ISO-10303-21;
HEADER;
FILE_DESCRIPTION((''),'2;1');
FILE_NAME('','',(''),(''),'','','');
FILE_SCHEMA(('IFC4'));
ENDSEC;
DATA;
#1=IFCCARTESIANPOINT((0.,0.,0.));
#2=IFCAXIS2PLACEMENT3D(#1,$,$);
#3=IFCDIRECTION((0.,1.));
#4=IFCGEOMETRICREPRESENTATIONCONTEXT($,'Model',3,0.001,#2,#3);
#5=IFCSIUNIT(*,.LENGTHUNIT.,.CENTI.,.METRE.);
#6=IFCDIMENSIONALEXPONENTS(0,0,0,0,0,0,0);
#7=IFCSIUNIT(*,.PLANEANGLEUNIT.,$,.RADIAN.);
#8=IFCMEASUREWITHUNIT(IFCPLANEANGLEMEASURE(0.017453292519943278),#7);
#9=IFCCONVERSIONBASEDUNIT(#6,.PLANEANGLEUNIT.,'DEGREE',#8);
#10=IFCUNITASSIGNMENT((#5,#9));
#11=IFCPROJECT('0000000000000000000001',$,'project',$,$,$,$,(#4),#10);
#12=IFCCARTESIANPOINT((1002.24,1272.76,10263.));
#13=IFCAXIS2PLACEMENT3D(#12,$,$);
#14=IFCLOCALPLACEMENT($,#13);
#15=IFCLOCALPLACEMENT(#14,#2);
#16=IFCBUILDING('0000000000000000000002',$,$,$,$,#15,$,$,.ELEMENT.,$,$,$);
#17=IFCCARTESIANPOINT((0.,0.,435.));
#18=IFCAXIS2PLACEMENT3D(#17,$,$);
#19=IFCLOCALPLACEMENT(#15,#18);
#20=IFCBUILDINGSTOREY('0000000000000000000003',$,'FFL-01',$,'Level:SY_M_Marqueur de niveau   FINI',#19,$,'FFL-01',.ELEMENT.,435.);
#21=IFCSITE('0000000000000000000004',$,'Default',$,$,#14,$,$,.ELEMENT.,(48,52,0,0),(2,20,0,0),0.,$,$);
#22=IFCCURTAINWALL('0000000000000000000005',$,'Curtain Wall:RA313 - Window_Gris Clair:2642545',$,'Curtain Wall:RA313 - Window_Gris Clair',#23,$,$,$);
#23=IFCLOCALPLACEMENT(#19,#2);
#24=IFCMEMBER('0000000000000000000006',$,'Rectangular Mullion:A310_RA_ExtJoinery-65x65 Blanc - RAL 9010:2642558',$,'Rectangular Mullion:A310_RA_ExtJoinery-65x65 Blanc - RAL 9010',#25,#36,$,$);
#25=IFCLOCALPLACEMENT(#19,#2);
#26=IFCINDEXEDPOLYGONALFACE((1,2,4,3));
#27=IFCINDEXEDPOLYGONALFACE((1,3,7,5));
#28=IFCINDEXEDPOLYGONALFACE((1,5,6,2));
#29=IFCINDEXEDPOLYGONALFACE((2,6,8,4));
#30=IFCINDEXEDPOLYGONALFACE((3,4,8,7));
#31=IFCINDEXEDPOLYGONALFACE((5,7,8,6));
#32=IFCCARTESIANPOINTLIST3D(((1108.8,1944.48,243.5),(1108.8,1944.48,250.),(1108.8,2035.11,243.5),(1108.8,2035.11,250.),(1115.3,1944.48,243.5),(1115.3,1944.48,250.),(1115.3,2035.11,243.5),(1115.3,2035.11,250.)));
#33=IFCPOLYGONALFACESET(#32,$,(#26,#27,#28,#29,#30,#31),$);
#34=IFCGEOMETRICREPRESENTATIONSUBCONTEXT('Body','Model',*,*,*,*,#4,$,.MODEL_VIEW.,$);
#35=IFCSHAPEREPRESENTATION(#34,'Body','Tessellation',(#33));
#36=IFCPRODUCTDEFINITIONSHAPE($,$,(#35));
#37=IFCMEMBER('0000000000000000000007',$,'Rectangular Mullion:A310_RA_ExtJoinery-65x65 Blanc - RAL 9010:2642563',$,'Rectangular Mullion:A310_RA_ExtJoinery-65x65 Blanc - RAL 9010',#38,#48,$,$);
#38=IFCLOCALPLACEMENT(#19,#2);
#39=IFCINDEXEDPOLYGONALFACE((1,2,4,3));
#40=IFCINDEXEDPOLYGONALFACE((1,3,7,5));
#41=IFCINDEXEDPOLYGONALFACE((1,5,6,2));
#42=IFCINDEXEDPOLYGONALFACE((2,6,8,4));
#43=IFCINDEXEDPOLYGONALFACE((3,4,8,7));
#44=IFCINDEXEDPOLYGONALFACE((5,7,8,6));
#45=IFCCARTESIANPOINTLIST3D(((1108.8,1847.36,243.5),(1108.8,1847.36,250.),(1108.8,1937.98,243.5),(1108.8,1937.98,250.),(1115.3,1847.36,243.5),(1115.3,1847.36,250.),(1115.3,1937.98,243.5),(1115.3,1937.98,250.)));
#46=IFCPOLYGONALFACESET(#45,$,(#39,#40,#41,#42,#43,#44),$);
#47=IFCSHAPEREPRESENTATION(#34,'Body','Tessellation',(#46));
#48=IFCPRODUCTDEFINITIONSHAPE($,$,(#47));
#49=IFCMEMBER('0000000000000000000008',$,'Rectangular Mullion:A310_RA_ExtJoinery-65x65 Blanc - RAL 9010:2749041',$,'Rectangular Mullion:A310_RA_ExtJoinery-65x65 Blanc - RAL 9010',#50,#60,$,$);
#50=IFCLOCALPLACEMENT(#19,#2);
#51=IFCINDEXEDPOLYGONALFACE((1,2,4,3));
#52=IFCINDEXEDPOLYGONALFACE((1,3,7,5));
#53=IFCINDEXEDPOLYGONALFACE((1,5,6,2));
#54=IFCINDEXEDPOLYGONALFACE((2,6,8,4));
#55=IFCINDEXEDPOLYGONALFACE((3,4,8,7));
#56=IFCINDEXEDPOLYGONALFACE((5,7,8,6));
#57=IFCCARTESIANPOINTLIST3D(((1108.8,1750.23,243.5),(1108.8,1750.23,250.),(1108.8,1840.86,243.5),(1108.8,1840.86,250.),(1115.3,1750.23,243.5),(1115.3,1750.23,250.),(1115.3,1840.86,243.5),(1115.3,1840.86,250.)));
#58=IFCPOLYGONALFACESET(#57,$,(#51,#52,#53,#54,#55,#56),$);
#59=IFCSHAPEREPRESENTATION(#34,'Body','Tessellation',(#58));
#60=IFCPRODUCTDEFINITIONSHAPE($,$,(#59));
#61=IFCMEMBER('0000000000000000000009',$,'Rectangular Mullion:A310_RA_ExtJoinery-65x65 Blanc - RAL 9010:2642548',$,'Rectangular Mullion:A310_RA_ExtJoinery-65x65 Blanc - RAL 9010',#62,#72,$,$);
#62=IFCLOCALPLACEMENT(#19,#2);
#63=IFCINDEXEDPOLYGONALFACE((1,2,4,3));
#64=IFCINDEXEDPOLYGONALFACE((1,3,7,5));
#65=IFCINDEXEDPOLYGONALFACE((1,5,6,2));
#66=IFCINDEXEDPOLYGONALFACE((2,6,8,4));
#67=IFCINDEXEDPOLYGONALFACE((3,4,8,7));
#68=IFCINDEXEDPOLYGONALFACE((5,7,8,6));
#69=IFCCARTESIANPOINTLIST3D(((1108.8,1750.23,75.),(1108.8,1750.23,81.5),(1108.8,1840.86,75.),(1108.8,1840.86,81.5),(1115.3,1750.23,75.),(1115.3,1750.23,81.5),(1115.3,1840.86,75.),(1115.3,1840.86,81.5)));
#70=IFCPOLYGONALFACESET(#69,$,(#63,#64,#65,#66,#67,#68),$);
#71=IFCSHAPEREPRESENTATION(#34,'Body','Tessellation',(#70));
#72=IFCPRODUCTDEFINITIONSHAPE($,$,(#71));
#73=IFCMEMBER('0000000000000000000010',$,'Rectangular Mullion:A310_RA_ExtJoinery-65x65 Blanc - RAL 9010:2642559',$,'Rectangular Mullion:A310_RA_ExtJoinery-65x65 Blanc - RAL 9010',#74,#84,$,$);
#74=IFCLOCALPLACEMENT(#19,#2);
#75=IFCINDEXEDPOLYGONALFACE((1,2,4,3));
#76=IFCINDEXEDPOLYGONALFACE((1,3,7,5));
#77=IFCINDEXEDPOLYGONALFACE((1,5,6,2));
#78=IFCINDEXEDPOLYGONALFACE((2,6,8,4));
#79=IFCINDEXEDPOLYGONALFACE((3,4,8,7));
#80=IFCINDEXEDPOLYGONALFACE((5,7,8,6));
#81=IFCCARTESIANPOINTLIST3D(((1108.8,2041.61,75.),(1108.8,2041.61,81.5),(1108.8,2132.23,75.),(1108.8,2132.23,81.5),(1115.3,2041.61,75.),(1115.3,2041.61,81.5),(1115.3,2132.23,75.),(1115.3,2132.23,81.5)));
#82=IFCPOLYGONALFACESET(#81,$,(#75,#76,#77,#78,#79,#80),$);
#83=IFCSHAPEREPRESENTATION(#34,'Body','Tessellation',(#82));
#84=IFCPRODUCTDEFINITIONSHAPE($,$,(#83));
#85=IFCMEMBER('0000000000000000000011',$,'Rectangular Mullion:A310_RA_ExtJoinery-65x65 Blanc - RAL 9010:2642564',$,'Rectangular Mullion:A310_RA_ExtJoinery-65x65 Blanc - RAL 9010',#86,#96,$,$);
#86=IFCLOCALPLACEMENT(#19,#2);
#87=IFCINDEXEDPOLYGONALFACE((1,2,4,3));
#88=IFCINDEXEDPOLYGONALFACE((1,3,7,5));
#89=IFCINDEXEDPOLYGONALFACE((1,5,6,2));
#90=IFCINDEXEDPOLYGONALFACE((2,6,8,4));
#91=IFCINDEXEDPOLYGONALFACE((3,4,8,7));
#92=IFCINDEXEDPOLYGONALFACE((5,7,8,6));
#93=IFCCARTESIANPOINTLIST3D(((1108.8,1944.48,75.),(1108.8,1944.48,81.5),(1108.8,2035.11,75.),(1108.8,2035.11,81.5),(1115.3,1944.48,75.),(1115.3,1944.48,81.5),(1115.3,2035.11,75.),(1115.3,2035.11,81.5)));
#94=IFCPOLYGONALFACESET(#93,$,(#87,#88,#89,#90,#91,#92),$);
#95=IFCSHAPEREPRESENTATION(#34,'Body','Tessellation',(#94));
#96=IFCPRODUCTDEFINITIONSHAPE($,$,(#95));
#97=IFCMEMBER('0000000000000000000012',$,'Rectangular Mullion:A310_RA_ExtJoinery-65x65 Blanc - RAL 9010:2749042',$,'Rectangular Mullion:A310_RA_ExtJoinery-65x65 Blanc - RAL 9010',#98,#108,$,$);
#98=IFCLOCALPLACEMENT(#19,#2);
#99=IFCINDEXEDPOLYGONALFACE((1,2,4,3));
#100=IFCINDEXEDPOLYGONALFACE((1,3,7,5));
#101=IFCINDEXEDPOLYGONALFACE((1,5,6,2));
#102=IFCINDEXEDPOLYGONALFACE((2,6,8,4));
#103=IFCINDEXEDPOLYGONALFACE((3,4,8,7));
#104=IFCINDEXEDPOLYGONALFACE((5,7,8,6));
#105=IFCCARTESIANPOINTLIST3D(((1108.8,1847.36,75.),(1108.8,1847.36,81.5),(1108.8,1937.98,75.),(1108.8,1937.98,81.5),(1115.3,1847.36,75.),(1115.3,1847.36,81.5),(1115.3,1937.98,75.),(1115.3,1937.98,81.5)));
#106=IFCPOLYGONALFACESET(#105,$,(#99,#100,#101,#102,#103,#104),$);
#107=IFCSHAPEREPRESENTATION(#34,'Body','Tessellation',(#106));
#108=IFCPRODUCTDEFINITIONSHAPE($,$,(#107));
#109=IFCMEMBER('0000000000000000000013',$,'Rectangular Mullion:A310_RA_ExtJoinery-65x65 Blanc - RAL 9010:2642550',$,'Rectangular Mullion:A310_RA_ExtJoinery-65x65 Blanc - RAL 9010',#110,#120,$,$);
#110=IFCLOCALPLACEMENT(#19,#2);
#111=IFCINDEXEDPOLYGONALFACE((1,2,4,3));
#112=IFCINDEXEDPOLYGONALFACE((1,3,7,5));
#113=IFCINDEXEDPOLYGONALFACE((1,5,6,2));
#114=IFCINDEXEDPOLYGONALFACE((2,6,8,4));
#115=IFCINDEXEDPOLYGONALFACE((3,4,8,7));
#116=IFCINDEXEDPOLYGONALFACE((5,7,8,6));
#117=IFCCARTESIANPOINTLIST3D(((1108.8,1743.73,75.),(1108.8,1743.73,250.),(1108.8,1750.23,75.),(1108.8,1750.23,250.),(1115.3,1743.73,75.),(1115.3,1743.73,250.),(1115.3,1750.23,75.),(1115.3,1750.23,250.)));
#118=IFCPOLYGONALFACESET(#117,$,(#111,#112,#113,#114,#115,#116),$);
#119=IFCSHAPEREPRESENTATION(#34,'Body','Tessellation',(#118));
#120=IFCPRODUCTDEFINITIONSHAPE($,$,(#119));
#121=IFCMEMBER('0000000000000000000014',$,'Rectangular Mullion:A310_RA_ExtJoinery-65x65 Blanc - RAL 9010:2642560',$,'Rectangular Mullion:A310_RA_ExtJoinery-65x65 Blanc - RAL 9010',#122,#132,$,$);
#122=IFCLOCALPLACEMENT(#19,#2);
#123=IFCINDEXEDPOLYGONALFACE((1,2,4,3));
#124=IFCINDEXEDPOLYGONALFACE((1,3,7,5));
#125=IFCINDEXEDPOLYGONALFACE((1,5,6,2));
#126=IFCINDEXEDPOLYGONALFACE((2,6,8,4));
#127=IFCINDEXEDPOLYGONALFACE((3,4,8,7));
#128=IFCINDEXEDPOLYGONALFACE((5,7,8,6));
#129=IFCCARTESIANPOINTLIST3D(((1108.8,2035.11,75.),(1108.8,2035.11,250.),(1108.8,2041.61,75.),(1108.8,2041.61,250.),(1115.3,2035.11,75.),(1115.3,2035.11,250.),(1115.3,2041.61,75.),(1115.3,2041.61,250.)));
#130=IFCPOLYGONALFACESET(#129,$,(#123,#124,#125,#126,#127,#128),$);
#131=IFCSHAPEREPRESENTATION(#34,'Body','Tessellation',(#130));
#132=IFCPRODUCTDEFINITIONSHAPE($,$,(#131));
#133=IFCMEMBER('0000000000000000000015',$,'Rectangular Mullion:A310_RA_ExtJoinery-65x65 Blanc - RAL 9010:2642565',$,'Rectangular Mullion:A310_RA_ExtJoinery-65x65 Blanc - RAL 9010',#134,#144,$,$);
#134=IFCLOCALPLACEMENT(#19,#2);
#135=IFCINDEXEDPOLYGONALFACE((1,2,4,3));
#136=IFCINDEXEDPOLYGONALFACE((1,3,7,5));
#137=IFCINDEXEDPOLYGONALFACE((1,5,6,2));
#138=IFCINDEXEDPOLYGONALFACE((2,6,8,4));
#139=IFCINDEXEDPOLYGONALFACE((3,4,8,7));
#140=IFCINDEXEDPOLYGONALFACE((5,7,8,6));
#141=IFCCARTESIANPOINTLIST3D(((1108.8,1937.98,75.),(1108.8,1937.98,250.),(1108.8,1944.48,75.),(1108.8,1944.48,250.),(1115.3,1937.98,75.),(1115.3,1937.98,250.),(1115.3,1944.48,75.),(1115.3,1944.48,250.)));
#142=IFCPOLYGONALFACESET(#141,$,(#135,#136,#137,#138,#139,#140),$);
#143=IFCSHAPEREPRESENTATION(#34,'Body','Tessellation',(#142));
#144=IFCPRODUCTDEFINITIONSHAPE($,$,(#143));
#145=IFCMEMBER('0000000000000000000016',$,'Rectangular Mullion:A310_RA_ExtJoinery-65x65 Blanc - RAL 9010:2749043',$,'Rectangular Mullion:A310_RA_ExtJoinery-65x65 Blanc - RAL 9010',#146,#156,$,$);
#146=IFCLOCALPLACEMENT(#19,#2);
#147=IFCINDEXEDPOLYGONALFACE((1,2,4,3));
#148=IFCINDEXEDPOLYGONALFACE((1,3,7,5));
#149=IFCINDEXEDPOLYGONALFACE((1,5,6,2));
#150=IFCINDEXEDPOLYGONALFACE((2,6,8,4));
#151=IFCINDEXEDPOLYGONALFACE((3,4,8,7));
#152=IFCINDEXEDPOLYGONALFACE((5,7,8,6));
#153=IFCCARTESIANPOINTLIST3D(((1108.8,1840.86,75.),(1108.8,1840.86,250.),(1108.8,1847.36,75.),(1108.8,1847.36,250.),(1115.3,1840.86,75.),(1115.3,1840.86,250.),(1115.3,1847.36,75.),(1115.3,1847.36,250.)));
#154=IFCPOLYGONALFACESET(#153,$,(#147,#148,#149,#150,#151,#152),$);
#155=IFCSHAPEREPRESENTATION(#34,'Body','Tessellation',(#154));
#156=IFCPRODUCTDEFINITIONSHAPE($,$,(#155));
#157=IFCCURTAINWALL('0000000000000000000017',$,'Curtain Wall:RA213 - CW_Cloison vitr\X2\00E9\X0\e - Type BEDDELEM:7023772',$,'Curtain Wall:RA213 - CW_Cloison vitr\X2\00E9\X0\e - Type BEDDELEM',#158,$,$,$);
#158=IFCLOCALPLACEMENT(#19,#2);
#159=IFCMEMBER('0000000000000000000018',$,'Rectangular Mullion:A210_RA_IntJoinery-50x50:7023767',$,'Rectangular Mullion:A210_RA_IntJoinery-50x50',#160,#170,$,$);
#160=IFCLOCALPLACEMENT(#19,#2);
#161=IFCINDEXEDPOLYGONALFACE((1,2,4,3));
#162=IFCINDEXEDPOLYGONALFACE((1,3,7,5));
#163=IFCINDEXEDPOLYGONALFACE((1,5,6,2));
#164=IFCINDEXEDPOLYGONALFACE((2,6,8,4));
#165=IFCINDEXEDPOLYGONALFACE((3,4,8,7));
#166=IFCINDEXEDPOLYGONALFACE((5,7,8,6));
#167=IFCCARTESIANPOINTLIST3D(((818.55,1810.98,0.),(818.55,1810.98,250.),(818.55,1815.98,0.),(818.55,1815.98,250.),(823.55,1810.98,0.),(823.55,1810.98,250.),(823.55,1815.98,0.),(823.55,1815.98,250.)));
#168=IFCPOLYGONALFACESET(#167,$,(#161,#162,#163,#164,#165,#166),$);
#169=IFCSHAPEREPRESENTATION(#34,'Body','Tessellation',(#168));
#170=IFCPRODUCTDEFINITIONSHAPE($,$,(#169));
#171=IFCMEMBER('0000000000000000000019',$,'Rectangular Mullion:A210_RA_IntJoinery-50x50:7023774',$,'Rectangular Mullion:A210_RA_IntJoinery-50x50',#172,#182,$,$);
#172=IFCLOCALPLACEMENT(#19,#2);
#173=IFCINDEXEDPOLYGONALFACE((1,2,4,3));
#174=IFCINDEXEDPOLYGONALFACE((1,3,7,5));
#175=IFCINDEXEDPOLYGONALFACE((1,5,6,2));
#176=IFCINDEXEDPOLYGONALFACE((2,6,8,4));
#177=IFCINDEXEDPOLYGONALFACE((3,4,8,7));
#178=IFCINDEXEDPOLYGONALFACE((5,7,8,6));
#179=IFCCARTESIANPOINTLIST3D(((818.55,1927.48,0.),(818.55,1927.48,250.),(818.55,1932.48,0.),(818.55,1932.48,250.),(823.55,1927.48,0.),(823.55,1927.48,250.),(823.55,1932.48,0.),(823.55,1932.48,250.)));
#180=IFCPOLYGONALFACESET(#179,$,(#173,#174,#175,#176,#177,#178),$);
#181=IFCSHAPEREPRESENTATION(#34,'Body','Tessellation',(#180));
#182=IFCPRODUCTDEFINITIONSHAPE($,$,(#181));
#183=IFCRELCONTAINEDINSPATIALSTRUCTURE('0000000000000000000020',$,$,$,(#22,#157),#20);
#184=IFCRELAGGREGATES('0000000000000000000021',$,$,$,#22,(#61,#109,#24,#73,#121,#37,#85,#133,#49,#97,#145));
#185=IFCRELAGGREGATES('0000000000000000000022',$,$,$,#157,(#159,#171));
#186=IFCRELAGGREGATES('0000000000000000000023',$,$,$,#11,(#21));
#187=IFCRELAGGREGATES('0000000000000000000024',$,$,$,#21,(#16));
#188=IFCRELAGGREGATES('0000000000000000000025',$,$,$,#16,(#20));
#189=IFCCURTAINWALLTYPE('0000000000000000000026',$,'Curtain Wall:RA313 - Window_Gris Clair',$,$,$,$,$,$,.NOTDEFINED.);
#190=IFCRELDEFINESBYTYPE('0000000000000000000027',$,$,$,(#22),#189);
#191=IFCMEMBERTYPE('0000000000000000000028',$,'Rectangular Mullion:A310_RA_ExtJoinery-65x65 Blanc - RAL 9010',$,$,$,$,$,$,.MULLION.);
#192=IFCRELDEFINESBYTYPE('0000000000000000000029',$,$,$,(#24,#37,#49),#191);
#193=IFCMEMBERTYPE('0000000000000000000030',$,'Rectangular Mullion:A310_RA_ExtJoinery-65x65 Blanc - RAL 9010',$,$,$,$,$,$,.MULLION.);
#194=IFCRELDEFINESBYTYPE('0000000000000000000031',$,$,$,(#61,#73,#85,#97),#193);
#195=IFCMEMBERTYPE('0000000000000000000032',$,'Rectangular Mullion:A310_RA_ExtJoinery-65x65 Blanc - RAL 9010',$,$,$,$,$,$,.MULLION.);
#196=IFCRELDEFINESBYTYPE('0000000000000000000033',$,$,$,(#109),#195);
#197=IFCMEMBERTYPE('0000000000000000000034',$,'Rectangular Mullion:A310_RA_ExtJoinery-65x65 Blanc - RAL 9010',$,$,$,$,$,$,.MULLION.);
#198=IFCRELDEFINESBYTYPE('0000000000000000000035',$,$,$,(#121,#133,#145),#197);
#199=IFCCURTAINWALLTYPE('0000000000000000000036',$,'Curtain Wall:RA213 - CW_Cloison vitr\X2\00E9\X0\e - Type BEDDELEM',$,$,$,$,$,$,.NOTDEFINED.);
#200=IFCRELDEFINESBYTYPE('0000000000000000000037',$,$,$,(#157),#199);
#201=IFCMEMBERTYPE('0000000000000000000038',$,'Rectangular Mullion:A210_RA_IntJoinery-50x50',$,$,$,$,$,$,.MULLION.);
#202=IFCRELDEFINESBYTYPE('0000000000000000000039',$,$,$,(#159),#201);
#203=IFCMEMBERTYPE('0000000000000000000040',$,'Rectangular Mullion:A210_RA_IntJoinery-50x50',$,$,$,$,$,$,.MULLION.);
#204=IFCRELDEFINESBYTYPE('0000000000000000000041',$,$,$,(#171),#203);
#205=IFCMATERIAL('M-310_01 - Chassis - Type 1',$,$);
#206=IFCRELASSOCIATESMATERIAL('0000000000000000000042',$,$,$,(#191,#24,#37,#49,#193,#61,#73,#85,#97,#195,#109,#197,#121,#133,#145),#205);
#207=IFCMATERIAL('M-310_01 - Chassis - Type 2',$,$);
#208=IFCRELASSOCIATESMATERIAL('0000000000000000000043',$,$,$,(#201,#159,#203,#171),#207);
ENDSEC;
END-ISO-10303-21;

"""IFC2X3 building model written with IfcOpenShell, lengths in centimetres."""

from ifc_helpers import new_model, entity, si_unit, converted_unit, direction, frame, origin, origin_2d_with_axis, place, context, subcontext, project, spatial, rectangle, extrude, source, transform, mapped, material, type_object, type_shapes, element, aggregate, save


model = new_model("IFC2X3")

# Units and contexts
model_context = context("Model", 3, precision=0.001, world=origin(), true_north=direction((0.0, 1.0)))
body_context = subcontext(model_context, "Body", "Model", "MODEL_VIEW")
ifc_project = project(units=[si_unit("LENGTHUNIT", "METRE", prefix="CENTI"), converted_unit("PLANEANGLEUNIT", "DEGREE", entity("IfcPlaneAngleMeasure", 0.017453292519943278), si_unit("PLANEANGLEUNIT", "RADIAN"), dimensions=[0, 0, 0, 0, 0, 0, 0])], contexts=[model_context])

# Site, building, storey
site_placement = place(None, frame((1002.24, 1272.76, 10263.0)))
site = spatial("IfcSite", under=ifc_project, at=site_placement, Name="Default", CompositionType="ELEMENT", RefLatitude=(48, 52, 0, 0), RefLongitude=(2, 20, 0, 0), RefElevation=0.0)
building_placement = place(site_placement, origin())
building = spatial("IfcBuilding", under=site, at=building_placement, CompositionType="ELEMENT")
storey_placement = place(building_placement, frame((0.0, 0.0, 435.0)))
storey = spatial("IfcBuildingStorey", under=building, at=storey_placement, Name="FFL-01", ObjectType="Level:SY_M_Marqueur de niveau   FINI", LongName="FFL-01", CompositionType="ELEMENT", Elevation=435.0)

# Curtain walls, members
curtain_wall_type_1 = type_object("IfcCurtainWallType", Name="Curtain Wall:RA313 - Window_Gris Clair", PredefinedType="NOTDEFINED")
curtain_wall_1_placement = place(storey_placement, frame((0.0, 0.0, -435.0)))
curtain_wall_1 = element("IfcCurtainWall", 1, at=curtain_wall_1_placement, inside=storey, type_object=curtain_wall_type_1, Name="Curtain Wall:RA313 - Window_Gris Clair:2642545", ObjectType="Curtain Wall:RA313 - Window_Gris Clair")
ifc_material_1 = material(Name="M-310_01 - Chassis - Type 1")
member_type_1 = type_object("IfcMemberType", Name="Rectangular Mullion:A310_RA_ExtJoinery-65x65 Blanc - RAL 9010", PredefinedType="MULLION", material=ifc_material_1)
shared_shape_1 = source(origin(), body_context, "Body", "SweptSolid", [
    extrude(rectangle(XDim=6.5, YDim=6.5, at=origin_2d_with_axis()), frame((-3.25, -3.25, -90.62), z_axis=(0.0, 0.0, 1.0), x_axis=(-1.0, 0.0, 0.0)), (0.0, 0.0, 1.0), 90.62),
])
type_shapes(member_type_1, [shared_shape_1])
member_1_placement = place(curtain_wall_1_placement, frame((1115.3, 2035.11, 685.0), z_axis=(0.0, 1.0, 0.0), x_axis=(0.0, 0.0, 1.0)))
member_1 = element("IfcMember", 2, at=member_1_placement, type_object=member_type_1, material=ifc_material_1, Name="Rectangular Mullion:A310_RA_ExtJoinery-65x65 Blanc - RAL 9010:2642558", ObjectType="Rectangular Mullion:A310_RA_ExtJoinery-65x65 Blanc - RAL 9010", context=body_context, shape_type="MappedRepresentation", body=[
    mapped(shared_shape_1, transform((0.0, 0.0, 0.0), scale=1.0)),
])
member_2_placement = place(curtain_wall_1_placement, frame((1115.3, 1937.98, 685.0), z_axis=(0.0, 1.0, 0.0), x_axis=(0.0, 0.0, 1.0)))
member_2 = element("IfcMember", 3, at=member_2_placement, type_object=member_type_1, material=ifc_material_1, Name="Rectangular Mullion:A310_RA_ExtJoinery-65x65 Blanc - RAL 9010:2642563", ObjectType="Rectangular Mullion:A310_RA_ExtJoinery-65x65 Blanc - RAL 9010", context=body_context, shape_type="MappedRepresentation", body=[
    mapped(shared_shape_1, transform((0.0, 0.0, 0.0), scale=1.0)),
])
member_3_placement = place(curtain_wall_1_placement, frame((1115.3, 1840.86, 685.0), z_axis=(0.0, 1.0, 0.0), x_axis=(0.0, 0.0, 1.0)))
member_3 = element("IfcMember", 4, at=member_3_placement, type_object=member_type_1, material=ifc_material_1, Name="Rectangular Mullion:A310_RA_ExtJoinery-65x65 Blanc - RAL 9010:2749041", ObjectType="Rectangular Mullion:A310_RA_ExtJoinery-65x65 Blanc - RAL 9010", context=body_context, shape_type="MappedRepresentation", body=[
    mapped(shared_shape_1, transform((0.0, 0.0, 0.0), scale=1.0)),
])
member_type_2 = type_object("IfcMemberType", Name="Rectangular Mullion:A310_RA_ExtJoinery-65x65 Blanc - RAL 9010", PredefinedType="MULLION", material=ifc_material_1)
shared_shape_2 = source(origin(), body_context, "Body", "SweptSolid", [
    extrude(rectangle(XDim=6.5, YDim=6.5, at=origin_2d_with_axis()), frame((-3.25, -3.25, -90.62), z_axis=(0.0, 0.0, 1.0), x_axis=(-1.0, 0.0, 0.0)), (0.0, 0.0, 1.0), 90.62),
])
type_shapes(member_type_2, [shared_shape_2])
member_4_placement = place(curtain_wall_1_placement, frame((1115.3, 1750.23, 510.0), z_axis=(0.0, -1.0, 0.0), x_axis=(0.0, 0.0, -1.0)))
member_4 = element("IfcMember", 5, at=member_4_placement, type_object=member_type_2, material=ifc_material_1, Name="Rectangular Mullion:A310_RA_ExtJoinery-65x65 Blanc - RAL 9010:2642548", ObjectType="Rectangular Mullion:A310_RA_ExtJoinery-65x65 Blanc - RAL 9010", context=body_context, shape_type="MappedRepresentation", body=[
    mapped(shared_shape_2, transform((0.0, 0.0, 0.0), scale=1.0)),
])
member_5_placement = place(curtain_wall_1_placement, frame((1115.3, 2041.61, 510.0), z_axis=(0.0, -1.0, 0.0), x_axis=(0.0, 0.0, -1.0)))
member_5 = element("IfcMember", 6, at=member_5_placement, type_object=member_type_2, material=ifc_material_1, Name="Rectangular Mullion:A310_RA_ExtJoinery-65x65 Blanc - RAL 9010:2642559", ObjectType="Rectangular Mullion:A310_RA_ExtJoinery-65x65 Blanc - RAL 9010", context=body_context, shape_type="MappedRepresentation", body=[
    mapped(shared_shape_2, transform((0.0, 0.0, 0.0), scale=1.0)),
])
member_6_placement = place(curtain_wall_1_placement, frame((1115.3, 1944.48, 510.0), z_axis=(0.0, -1.0, 0.0), x_axis=(0.0, 0.0, -1.0)))
member_6 = element("IfcMember", 7, at=member_6_placement, type_object=member_type_2, material=ifc_material_1, Name="Rectangular Mullion:A310_RA_ExtJoinery-65x65 Blanc - RAL 9010:2642564", ObjectType="Rectangular Mullion:A310_RA_ExtJoinery-65x65 Blanc - RAL 9010", context=body_context, shape_type="MappedRepresentation", body=[
    mapped(shared_shape_2, transform((0.0, 0.0, 0.0), scale=1.0)),
])
member_7_placement = place(curtain_wall_1_placement, frame((1115.3, 1847.36, 510.0), z_axis=(0.0, -1.0, 0.0), x_axis=(0.0, 0.0, -1.0)))
member_7 = element("IfcMember", 8, at=member_7_placement, type_object=member_type_2, material=ifc_material_1, Name="Rectangular Mullion:A310_RA_ExtJoinery-65x65 Blanc - RAL 9010:2749042", ObjectType="Rectangular Mullion:A310_RA_ExtJoinery-65x65 Blanc - RAL 9010", context=body_context, shape_type="MappedRepresentation", body=[
    mapped(shared_shape_2, transform((0.0, 0.0, 0.0), scale=1.0)),
])
member_type_3 = type_object("IfcMemberType", Name="Rectangular Mullion:A310_RA_ExtJoinery-65x65 Blanc - RAL 9010", PredefinedType="MULLION", material=ifc_material_1)
shared_shape_3 = source(origin(), body_context, "Body", "SweptSolid", [
    extrude(rectangle(XDim=6.5, YDim=6.5, at=origin_2d_with_axis()), frame((-3.25, -3.25, -175.0), z_axis=(0.0, 0.0, 1.0), x_axis=(-1.0, 0.0, 0.0)), (0.0, 0.0, 1.0), 175.0),
])
type_shapes(member_type_3, [shared_shape_3])
member_8_placement = place(curtain_wall_1_placement, frame((1115.3, 1743.73, 685.0), z_axis=(0.0, 0.0, 1.0), x_axis=(0.0, -1.0, 0.0)))
member_8 = element("IfcMember", 9, at=member_8_placement, type_object=member_type_3, material=ifc_material_1, Name="Rectangular Mullion:A310_RA_ExtJoinery-65x65 Blanc - RAL 9010:2642550", ObjectType="Rectangular Mullion:A310_RA_ExtJoinery-65x65 Blanc - RAL 9010", context=body_context, shape_type="MappedRepresentation", body=[
    mapped(shared_shape_3, transform((0.0, 0.0, 0.0), scale=1.0)),
])
member_type_4 = type_object("IfcMemberType", Name="Rectangular Mullion:A310_RA_ExtJoinery-65x65 Blanc - RAL 9010", PredefinedType="MULLION", material=ifc_material_1)
shared_shape_4 = source(origin(), body_context, "Body", "SweptSolid", [
    extrude(rectangle(XDim=6.5, YDim=6.5, at=origin_2d_with_axis()), frame((0.0, -3.25, -175.0), z_axis=(0.0, 0.0, 1.0), x_axis=(-1.0, 0.0, 0.0)), (0.0, 0.0, 1.0), 175.0),
])
type_shapes(member_type_4, [shared_shape_4])
member_9_placement = place(curtain_wall_1_placement, frame((1115.3, 2038.36, 510.0), z_axis=(0.0, 0.0, -1.0), x_axis=(0.0, 1.0, 0.0)))
member_9 = element("IfcMember", 10, at=member_9_placement, type_object=member_type_4, material=ifc_material_1, Name="Rectangular Mullion:A310_RA_ExtJoinery-65x65 Blanc - RAL 9010:2642560", ObjectType="Rectangular Mullion:A310_RA_ExtJoinery-65x65 Blanc - RAL 9010", context=body_context, shape_type="MappedRepresentation", body=[
    mapped(shared_shape_4, transform((0.0, 0.0, 0.0), scale=1.0)),
])
member_10_placement = place(curtain_wall_1_placement, frame((1115.3, 1941.23, 510.0), z_axis=(0.0, 0.0, -1.0), x_axis=(0.0, 1.0, 0.0)))
member_10 = element("IfcMember", 11, at=member_10_placement, type_object=member_type_4, material=ifc_material_1, Name="Rectangular Mullion:A310_RA_ExtJoinery-65x65 Blanc - RAL 9010:2642565", ObjectType="Rectangular Mullion:A310_RA_ExtJoinery-65x65 Blanc - RAL 9010", context=body_context, shape_type="MappedRepresentation", body=[
    mapped(shared_shape_4, transform((0.0, 0.0, 0.0), scale=1.0)),
])
member_11_placement = place(curtain_wall_1_placement, frame((1115.3, 1844.11, 510.0), z_axis=(0.0, 0.0, -1.0), x_axis=(0.0, 1.0, 0.0)))
member_11 = element("IfcMember", 12, at=member_11_placement, type_object=member_type_4, material=ifc_material_1, Name="Rectangular Mullion:A310_RA_ExtJoinery-65x65 Blanc - RAL 9010:2749043", ObjectType="Rectangular Mullion:A310_RA_ExtJoinery-65x65 Blanc - RAL 9010", context=body_context, shape_type="MappedRepresentation", body=[
    mapped(shared_shape_4, transform((0.0, 0.0, 0.0), scale=1.0)),
])
curtain_wall_type_2 = type_object("IfcCurtainWallType", Name="Curtain Wall:RA213 - CW_Cloison vitrée - Type BEDDELEM", PredefinedType="NOTDEFINED")
curtain_wall_2_placement = place(storey_placement, frame((0.0, 0.0, -435.0)))
curtain_wall_2 = element("IfcCurtainWall", 13, at=curtain_wall_2_placement, inside=storey, type_object=curtain_wall_type_2, Name="Curtain Wall:RA213 - CW_Cloison vitrée - Type BEDDELEM:7023772", ObjectType="Curtain Wall:RA213 - CW_Cloison vitrée - Type BEDDELEM")
ifc_material_2 = material(Name="M-310_01 - Chassis - Type 2")
member_type_5 = type_object("IfcMemberType", Name="Rectangular Mullion:A210_RA_IntJoinery-50x50", PredefinedType="MULLION", material=ifc_material_2)
shared_shape_5 = source(origin(), body_context, "Body", "SweptSolid", [
    extrude(rectangle(XDim=5.0, YDim=5.0, at=origin_2d_with_axis()), frame((0.0, -2.5, -250.0), z_axis=(0.0, 0.0, 1.0), x_axis=(-1.0, 0.0, 0.0)), (0.0, 0.0, 1.0), 250.0),
])
type_shapes(member_type_5, [shared_shape_5])
member_12_placement = place(curtain_wall_2_placement, frame((818.55, 1813.48, 435.0), z_axis=(0.0, 0.0, -1.0), x_axis=(0.0, -1.0, 0.0)))
member_12 = element("IfcMember", 14, at=member_12_placement, type_object=member_type_5, material=ifc_material_2, Name="Rectangular Mullion:A210_RA_IntJoinery-50x50:7023767", ObjectType="Rectangular Mullion:A210_RA_IntJoinery-50x50", context=body_context, shape_type="MappedRepresentation", body=[
    mapped(shared_shape_5, transform((0.0, 0.0, 0.0), scale=1.0)),
])
member_type_6 = type_object("IfcMemberType", Name="Rectangular Mullion:A210_RA_IntJoinery-50x50", PredefinedType="MULLION", material=ifc_material_2)
shared_shape_6 = source(origin(), body_context, "Body", "SweptSolid", [
    extrude(rectangle(XDim=5.0, YDim=5.0, at=origin_2d_with_axis()), frame((-2.5, -2.5, -250.0), z_axis=(0.0, 0.0, 1.0), x_axis=(-1.0, 0.0, 0.0)), (0.0, 0.0, 1.0), 250.0),
])
type_shapes(member_type_6, [shared_shape_6])
member_13_placement = place(curtain_wall_2_placement, frame((818.55, 1932.48, 685.0), z_axis=(0.0, 0.0, 1.0), x_axis=(0.0, 1.0, 0.0)))
member_13 = element("IfcMember", 15, at=member_13_placement, type_object=member_type_6, material=ifc_material_2, Name="Rectangular Mullion:A210_RA_IntJoinery-50x50:7023774", ObjectType="Rectangular Mullion:A210_RA_IntJoinery-50x50", context=body_context, shape_type="MappedRepresentation", body=[
    mapped(shared_shape_6, transform((0.0, 0.0, 0.0), scale=1.0)),
])

aggregate(curtain_wall_1, [member_4, member_8, member_1, member_5, member_9, member_2, member_6, member_10, member_3, member_7, member_11])

aggregate(curtain_wall_2, [member_12, member_13])

save(model, "model.ifc")
